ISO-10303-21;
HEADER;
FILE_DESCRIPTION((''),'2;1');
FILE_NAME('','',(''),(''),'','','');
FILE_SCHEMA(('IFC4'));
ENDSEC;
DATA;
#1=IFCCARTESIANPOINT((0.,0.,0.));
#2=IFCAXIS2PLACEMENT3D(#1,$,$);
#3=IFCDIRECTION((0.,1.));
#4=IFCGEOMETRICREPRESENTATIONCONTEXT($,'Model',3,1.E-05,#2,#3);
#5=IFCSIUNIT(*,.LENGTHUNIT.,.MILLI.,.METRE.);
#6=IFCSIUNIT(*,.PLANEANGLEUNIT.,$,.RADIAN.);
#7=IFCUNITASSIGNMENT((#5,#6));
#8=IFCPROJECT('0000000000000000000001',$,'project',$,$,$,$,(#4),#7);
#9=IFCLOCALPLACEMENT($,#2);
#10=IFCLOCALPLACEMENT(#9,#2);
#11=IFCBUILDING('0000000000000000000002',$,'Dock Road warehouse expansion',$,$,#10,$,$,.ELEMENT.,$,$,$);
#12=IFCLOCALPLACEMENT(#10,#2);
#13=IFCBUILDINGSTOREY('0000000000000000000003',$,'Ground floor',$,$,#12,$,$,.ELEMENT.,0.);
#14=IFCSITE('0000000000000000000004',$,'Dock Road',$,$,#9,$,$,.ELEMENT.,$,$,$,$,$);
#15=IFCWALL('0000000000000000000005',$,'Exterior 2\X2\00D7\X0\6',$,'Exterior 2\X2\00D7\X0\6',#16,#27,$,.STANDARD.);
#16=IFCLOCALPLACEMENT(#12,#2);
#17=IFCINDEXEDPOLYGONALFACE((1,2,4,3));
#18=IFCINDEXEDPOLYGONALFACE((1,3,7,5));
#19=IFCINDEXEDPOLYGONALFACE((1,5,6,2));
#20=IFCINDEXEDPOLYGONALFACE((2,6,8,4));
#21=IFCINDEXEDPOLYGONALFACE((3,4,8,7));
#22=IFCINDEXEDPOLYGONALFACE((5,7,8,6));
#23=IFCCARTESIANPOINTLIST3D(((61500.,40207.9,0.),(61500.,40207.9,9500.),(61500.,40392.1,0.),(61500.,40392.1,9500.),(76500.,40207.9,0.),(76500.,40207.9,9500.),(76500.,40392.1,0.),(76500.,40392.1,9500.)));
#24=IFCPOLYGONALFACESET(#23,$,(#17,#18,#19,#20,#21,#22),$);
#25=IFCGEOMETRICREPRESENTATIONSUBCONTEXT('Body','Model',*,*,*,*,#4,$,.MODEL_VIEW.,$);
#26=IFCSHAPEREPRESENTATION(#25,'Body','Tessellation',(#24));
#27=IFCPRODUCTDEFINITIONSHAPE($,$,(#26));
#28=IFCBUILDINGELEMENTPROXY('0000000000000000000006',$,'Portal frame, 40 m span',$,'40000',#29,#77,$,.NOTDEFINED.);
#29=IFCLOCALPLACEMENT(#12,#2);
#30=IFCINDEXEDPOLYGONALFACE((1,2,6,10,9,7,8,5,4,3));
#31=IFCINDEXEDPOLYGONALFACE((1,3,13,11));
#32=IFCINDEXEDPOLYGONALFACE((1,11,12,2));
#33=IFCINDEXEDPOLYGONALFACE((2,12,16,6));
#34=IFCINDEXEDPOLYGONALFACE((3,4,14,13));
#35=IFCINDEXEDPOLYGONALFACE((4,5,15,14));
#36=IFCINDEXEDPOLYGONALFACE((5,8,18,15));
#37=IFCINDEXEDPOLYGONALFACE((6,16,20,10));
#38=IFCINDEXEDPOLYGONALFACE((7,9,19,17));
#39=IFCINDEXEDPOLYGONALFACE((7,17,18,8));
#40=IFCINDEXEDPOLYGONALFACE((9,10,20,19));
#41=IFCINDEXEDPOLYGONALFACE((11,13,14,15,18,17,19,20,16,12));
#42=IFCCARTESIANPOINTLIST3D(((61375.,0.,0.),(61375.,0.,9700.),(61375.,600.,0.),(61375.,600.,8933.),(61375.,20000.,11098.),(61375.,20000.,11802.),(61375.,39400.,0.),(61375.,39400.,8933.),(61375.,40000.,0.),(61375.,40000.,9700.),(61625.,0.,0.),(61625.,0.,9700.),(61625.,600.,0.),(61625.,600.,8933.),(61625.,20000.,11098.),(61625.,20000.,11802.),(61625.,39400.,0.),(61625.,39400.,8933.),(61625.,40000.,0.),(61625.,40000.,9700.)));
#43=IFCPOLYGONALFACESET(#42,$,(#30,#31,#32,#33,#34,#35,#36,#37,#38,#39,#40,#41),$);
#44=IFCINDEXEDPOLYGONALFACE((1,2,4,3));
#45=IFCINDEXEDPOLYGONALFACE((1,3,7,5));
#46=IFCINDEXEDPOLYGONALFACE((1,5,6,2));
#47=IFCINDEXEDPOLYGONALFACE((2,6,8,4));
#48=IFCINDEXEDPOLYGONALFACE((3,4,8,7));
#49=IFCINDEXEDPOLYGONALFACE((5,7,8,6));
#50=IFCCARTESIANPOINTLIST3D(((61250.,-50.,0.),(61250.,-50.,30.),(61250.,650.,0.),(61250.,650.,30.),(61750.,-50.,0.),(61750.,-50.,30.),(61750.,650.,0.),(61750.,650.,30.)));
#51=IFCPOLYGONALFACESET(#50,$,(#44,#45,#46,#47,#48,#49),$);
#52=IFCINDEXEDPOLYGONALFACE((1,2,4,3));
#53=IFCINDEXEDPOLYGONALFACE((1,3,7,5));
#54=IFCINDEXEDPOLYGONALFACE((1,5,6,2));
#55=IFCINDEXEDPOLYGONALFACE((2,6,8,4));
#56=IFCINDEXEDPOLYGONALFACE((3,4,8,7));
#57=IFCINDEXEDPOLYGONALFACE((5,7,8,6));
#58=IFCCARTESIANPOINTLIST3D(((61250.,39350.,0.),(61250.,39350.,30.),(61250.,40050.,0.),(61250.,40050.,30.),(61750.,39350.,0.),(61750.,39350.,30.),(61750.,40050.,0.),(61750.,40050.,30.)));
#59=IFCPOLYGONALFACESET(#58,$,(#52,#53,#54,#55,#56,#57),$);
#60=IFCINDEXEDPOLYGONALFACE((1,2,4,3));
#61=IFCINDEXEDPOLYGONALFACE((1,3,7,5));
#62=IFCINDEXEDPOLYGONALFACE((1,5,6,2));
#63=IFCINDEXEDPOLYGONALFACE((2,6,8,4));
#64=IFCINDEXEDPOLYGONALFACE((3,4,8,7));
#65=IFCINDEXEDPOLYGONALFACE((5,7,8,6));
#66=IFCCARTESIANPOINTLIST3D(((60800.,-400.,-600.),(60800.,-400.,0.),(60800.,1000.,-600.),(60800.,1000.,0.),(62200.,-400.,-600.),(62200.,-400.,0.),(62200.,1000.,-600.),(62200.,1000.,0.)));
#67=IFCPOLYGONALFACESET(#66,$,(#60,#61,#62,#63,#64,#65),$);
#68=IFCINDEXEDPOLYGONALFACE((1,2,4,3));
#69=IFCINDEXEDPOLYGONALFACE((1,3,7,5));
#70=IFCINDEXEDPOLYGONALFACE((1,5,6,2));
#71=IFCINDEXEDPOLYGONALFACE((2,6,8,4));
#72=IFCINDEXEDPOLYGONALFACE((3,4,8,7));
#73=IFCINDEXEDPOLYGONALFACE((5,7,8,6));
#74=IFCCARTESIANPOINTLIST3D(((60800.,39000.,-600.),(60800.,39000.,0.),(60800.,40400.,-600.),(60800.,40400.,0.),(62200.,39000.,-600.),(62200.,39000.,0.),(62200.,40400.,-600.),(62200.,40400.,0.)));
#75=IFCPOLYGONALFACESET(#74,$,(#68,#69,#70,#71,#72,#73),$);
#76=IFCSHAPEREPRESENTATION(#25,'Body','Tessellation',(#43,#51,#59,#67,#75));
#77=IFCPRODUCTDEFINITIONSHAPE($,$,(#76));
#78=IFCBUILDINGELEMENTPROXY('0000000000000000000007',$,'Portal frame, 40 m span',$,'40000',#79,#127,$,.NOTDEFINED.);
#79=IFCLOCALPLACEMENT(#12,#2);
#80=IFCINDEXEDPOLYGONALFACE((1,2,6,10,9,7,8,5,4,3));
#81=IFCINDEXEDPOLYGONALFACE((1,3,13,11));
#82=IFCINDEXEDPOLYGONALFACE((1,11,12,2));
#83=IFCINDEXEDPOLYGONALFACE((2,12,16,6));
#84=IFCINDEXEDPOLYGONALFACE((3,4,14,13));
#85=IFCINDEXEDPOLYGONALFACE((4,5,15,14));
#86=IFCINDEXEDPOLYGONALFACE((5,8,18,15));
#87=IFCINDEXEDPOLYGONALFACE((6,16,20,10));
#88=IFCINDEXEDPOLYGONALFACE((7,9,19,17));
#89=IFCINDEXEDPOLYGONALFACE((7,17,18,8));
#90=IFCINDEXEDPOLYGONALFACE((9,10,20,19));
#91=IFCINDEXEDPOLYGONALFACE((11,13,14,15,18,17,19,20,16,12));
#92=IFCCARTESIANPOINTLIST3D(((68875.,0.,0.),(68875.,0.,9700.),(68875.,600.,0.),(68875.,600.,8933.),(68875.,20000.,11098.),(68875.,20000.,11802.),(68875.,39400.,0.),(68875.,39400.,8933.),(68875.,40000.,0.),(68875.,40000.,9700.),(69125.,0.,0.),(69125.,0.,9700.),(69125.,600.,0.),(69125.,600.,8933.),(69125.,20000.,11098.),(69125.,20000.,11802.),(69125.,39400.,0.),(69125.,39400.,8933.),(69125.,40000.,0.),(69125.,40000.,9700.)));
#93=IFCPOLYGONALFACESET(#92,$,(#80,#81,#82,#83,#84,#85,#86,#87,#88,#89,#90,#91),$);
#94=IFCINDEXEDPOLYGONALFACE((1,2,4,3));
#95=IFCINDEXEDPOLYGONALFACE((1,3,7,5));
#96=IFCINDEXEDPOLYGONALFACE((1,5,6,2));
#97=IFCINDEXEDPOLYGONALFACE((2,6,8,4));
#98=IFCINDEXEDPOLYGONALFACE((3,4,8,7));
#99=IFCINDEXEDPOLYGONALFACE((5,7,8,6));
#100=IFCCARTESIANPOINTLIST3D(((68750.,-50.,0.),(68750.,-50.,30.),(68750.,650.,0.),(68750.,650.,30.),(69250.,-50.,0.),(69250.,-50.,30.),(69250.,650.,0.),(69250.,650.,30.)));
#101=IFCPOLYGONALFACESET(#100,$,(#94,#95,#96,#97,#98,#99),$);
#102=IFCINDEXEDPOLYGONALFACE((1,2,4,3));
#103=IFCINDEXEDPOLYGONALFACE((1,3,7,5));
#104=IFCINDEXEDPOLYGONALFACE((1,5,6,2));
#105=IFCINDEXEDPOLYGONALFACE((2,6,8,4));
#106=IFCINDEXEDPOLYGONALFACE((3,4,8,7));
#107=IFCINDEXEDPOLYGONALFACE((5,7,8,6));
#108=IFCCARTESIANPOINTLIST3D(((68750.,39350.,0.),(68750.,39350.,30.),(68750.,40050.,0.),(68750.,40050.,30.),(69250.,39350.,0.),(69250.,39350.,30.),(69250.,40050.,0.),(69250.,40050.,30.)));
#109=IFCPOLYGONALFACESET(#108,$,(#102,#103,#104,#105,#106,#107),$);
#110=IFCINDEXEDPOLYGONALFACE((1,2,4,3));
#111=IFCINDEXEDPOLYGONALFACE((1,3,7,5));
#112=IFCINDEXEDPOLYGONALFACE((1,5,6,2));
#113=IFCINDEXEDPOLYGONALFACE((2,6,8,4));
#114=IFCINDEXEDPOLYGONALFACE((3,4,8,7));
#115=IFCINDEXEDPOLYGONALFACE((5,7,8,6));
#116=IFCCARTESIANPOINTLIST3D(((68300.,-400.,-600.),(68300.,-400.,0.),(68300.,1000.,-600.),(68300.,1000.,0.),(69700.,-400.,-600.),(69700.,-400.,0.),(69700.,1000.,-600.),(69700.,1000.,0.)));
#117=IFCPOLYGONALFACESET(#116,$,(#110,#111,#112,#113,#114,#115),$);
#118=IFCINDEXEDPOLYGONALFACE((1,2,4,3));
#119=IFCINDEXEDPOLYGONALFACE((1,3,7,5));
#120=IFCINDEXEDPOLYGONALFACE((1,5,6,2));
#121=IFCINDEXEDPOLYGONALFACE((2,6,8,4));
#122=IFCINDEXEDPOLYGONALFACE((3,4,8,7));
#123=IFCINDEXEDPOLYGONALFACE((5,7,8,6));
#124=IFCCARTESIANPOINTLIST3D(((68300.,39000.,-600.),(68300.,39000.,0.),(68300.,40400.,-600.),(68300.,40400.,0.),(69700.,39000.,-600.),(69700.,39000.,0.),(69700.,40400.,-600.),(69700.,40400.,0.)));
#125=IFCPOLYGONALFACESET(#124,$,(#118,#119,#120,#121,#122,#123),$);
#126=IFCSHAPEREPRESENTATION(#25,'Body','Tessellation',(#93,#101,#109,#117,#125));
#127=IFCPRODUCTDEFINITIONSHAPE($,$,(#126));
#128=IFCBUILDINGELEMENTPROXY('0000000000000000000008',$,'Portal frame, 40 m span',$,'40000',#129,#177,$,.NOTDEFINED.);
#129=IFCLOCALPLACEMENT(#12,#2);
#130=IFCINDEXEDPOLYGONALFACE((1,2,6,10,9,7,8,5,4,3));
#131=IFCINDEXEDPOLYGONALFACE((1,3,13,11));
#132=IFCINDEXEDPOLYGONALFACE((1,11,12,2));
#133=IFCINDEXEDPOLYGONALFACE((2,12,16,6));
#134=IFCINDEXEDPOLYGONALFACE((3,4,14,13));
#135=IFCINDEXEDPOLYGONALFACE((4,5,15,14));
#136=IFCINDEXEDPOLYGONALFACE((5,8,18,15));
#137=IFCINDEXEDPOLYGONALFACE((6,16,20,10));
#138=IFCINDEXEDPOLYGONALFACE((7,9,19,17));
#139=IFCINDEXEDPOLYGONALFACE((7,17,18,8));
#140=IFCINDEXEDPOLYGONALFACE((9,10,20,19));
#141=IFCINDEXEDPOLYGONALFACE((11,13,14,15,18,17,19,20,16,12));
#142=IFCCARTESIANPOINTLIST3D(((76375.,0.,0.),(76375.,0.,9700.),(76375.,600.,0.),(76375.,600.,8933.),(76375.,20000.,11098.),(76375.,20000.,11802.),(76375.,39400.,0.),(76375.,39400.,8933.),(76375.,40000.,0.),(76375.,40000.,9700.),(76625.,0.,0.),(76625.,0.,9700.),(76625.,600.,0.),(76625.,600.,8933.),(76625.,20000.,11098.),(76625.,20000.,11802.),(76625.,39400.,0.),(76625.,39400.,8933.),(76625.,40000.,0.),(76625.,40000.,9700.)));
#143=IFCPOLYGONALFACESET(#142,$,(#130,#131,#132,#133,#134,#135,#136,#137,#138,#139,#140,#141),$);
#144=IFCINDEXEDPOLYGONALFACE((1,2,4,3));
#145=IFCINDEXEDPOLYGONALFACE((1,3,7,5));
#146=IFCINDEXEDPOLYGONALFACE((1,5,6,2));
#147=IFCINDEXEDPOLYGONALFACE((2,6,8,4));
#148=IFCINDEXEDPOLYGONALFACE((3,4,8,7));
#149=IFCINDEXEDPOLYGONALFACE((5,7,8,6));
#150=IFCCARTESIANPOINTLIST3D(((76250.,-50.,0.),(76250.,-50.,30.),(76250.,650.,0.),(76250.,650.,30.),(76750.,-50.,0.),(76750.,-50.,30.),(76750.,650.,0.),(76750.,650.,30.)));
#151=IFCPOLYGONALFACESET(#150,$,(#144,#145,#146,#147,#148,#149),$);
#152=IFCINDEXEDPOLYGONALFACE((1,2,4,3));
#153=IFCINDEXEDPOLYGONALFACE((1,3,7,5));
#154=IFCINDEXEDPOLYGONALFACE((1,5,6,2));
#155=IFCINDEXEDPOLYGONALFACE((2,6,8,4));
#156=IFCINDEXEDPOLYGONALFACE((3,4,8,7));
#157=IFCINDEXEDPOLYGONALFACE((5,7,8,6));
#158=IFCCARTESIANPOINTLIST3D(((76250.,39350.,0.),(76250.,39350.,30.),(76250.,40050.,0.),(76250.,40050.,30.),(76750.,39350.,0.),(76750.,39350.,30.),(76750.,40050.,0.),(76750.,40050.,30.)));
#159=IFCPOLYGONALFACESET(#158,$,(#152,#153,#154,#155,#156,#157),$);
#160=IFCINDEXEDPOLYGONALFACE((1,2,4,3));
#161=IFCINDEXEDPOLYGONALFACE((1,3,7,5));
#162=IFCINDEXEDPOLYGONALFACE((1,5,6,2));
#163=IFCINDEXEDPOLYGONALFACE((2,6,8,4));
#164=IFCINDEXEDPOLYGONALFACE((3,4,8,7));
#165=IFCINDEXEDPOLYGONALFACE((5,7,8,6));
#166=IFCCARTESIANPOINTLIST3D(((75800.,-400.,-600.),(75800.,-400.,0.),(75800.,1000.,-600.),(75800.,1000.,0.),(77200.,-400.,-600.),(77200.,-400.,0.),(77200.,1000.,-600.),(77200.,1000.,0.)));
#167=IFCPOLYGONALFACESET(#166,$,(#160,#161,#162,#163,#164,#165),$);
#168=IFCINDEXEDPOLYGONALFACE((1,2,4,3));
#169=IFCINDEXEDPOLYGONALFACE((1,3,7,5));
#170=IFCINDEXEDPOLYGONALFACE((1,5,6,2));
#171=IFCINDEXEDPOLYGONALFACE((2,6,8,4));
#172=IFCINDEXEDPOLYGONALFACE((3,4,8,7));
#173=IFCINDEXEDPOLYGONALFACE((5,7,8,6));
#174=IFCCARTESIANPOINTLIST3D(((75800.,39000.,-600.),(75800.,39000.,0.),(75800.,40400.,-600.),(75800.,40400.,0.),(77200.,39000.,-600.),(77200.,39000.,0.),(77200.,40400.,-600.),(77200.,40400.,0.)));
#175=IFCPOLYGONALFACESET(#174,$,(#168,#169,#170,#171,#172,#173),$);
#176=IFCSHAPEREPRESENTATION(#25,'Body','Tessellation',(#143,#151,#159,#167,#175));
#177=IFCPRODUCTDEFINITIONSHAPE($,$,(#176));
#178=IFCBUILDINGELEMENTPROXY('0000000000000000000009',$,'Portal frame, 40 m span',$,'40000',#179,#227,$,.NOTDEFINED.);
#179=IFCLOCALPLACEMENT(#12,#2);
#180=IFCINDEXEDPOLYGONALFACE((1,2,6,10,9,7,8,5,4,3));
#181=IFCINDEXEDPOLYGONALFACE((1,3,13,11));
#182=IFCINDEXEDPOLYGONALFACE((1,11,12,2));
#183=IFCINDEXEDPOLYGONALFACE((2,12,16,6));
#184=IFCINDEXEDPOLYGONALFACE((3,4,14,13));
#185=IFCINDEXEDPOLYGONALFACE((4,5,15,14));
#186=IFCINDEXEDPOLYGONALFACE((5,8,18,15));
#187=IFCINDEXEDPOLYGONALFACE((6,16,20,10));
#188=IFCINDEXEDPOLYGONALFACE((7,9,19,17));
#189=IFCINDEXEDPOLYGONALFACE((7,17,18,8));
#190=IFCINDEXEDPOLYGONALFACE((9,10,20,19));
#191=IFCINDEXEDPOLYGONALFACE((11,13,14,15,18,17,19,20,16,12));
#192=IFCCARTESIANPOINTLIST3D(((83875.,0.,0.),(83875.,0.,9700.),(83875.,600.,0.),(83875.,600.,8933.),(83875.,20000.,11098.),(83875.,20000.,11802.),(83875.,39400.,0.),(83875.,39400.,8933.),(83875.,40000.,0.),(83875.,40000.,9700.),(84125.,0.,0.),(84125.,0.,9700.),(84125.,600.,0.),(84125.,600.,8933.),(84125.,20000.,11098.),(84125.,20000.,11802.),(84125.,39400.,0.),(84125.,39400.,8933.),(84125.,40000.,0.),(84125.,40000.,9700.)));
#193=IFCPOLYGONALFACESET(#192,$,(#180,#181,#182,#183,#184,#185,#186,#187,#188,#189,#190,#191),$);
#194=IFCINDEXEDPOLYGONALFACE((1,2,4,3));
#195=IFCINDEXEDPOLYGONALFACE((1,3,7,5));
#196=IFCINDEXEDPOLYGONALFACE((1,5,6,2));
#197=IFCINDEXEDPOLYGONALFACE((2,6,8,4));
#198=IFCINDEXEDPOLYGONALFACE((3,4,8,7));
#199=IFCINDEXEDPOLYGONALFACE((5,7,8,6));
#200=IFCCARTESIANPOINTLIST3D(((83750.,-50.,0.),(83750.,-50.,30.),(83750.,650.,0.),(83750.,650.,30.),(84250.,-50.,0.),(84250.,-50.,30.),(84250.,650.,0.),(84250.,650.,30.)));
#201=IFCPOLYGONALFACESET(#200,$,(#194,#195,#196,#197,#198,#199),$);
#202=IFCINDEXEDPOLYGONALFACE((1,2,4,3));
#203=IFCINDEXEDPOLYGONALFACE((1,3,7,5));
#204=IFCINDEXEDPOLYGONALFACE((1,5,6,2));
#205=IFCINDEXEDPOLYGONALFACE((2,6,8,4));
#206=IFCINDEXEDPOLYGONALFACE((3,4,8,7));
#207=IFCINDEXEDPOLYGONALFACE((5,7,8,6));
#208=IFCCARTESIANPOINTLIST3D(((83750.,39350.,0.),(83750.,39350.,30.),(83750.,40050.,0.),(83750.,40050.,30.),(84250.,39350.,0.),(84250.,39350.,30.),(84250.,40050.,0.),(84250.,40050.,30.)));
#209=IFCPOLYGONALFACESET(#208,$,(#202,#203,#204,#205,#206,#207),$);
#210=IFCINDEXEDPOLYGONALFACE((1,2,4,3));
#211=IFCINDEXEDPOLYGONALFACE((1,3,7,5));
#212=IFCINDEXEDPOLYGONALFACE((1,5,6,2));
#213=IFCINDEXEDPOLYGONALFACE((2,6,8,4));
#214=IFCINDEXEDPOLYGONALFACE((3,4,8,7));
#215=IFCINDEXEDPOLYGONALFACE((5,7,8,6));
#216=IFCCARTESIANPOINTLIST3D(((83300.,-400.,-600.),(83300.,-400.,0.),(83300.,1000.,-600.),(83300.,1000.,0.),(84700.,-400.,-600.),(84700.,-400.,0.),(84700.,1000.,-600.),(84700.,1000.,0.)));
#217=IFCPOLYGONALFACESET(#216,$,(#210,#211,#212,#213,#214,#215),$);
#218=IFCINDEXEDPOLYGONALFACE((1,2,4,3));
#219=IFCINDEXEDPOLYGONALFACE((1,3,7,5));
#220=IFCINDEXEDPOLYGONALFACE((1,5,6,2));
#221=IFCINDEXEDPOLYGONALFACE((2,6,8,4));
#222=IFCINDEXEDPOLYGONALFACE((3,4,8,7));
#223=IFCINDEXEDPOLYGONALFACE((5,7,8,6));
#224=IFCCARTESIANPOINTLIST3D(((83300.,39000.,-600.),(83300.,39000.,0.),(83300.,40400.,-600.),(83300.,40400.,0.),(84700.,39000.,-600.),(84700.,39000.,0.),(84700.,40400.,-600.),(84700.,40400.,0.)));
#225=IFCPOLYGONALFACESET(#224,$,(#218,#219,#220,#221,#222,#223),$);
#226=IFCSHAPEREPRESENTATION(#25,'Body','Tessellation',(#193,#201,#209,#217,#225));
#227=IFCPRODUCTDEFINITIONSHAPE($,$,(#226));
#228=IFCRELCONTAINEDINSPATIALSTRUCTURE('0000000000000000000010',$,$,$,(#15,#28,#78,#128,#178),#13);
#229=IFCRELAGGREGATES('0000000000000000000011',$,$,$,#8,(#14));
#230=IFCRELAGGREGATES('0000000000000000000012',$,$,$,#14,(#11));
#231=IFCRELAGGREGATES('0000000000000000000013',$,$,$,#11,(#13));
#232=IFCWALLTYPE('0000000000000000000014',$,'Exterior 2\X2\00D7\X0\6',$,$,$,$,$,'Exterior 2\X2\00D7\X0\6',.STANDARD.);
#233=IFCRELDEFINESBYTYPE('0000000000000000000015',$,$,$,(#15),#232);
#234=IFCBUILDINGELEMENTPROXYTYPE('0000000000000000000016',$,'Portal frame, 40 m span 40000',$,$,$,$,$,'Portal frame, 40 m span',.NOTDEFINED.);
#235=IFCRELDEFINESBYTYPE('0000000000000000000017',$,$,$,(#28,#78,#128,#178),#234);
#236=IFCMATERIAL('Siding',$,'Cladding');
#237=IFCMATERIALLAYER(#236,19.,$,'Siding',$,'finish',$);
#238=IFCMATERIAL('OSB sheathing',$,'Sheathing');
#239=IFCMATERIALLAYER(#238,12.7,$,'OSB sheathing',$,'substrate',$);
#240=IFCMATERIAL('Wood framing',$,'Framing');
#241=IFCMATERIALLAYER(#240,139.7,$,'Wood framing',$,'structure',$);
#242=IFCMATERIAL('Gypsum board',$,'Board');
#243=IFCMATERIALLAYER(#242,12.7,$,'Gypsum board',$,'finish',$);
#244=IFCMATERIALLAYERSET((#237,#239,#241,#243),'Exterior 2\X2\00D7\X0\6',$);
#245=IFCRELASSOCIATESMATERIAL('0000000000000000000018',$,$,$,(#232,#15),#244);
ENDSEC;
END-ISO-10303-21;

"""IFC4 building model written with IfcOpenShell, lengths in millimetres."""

from ifc_helpers import new_model, si_unit, direction, frame, origin, place, context, subcontext, project, spatial, polyline, outline, extrude, source, transform, mapped, material, layer, layer_set, layer_usage, type_object, type_shapes, element, save


model = new_model("IFC4")

# Units and contexts
model_context = context("Model", 3, precision=1e-05, world=origin(), true_north=direction((0.0, 1.0)))
body_context = subcontext(model_context, "Body", "Model", "MODEL_VIEW")
ifc_project = project(units=[si_unit("LENGTHUNIT", "METRE", prefix="MILLI"), si_unit("PLANEANGLEUNIT", "RADIAN")], contexts=[model_context])

# Site, building, storey
site_placement = place(None, origin())
site = spatial("IfcSite", under=ifc_project, at=site_placement, Name="Dock Road", CompositionType="ELEMENT")
building_placement = place(site_placement, origin())
building = spatial("IfcBuilding", under=site, at=building_placement, Name="Dock Road warehouse expansion", CompositionType="ELEMENT")
storey_placement = place(building_placement, origin())
storey = spatial("IfcBuildingStorey", under=building, at=storey_placement, Name="Ground floor", CompositionType="ELEMENT", Elevation=0.0)

# Wall
ifc_material_1 = material(Name="Siding", Category="Cladding")
ifc_layer_1 = layer(ifc_material_1, 19.0, Name="Siding", Category="finish")
ifc_material_2 = material(Name="OSB sheathing", Category="Sheathing")
ifc_layer_2 = layer(ifc_material_2, 12.7, Name="OSB sheathing", Category="substrate")
ifc_material_3 = material(Name="Wood framing", Category="Framing")
ifc_layer_3 = layer(ifc_material_3, 139.7, Name="Wood framing", Category="structure")
ifc_material_4 = material(Name="Gypsum board", Category="Board")
ifc_layer_4 = layer(ifc_material_4, 12.7, Name="Gypsum board", Category="finish")
ifc_layer_set_1 = layer_set([ifc_layer_1, ifc_layer_2, ifc_layer_3, ifc_layer_4], Name="Exterior 2×6")
ifc_layer_usage_1 = layer_usage(ifc_layer_set_1, "AXIS2", "NEGATIVE", 92.1)
wall_type_1 = type_object("IfcWallType", Name="Exterior 2×6", ElementType="Exterior 2×6", PredefinedType="STANDARD", material=ifc_layer_set_1)
wall_1_placement = place(storey_placement, frame((61500.0, 40300.0, 0.0), z_axis=(0.0, 0.0, 1.0), x_axis=(1.0, 0.0, 0.0)))
element("IfcWall", 1, at=wall_1_placement, inside=storey, type_object=wall_type_1, material=ifc_layer_usage_1, Name="Exterior 2×6", ObjectType="Exterior 2×6", PredefinedType="STANDARD", context=body_context, shape_type="SweptSolid", body=[
    extrude(outline(polyline([(0.0, -92.1), (15000.0, -92.1), (15000.0, 92.1), (0.0, 92.1), (0.0, -92.1)])), origin(), (0.0, 0.0, 1.0), 9500.0),
])

# Building element proxies
building_element_proxy_type_1 = type_object("IfcBuildingElementProxyType", Name="Portal frame, 40 m span 40000", ElementType="Portal frame, 40 m span", PredefinedType="NOTDEFINED")
shared_shape_1 = source(origin(), body_context, "Body", "SweptSolid", [
    extrude(outline(polyline([(0.0, 0.0), (0.0, 9700.0), (20000.0, 11802.0), (40000.0, 9700.0), (40000.0, 0.0), (39400.0, 0.0), (39400.0, 8933.0), (20000.0, 11098.0), (600.0, 8933.0), (600.0, 0.0), (0.0, 0.0)])), frame((-125.0, 0.0, 0.0), z_axis=(1.0, 0.0, 0.0), x_axis=(0.0, 1.0, 0.0)), (0.0, 0.0, 1.0), 250.0),
    extrude(outline(polyline([(-250.0, -50.0), (250.0, -50.0), (250.0, 650.0), (-250.0, 650.0), (-250.0, -50.0)])), origin(), (0.0, 0.0, 1.0), 30.0),
    extrude(outline(polyline([(-250.0, 39350.0), (250.0, 39350.0), (250.0, 40050.0), (-250.0, 40050.0), (-250.0, 39350.0)])), origin(), (0.0, 0.0, 1.0), 30.0),
    extrude(outline(polyline([(-700.0, -400.0), (700.0, -400.0), (700.0, 1000.0), (-700.0, 1000.0), (-700.0, -400.0)])), frame((0.0, 0.0, -600.0)), (0.0, 0.0, 1.0), 600.0),
    extrude(outline(polyline([(-700.0, 39000.0), (700.0, 39000.0), (700.0, 40400.0), (-700.0, 40400.0), (-700.0, 39000.0)])), frame((0.0, 0.0, -600.0)), (0.0, 0.0, 1.0), 600.0),
])
type_shapes(building_element_proxy_type_1, [shared_shape_1])
for number, where, z_axis, x_axis, name in (
    (2, (61500.0, 0.0, 0.0), (0.0, 0.0, 1.0), (1.0, 0.0, 0.0), "Portal frame, 40 m span"),
    (3, (69000.0, 0.0, 0.0), (0.0, 0.0, 1.0), (1.0, 0.0, 0.0), "Portal frame, 40 m span"),
    (4, (76500.0, 0.0, 0.0), (0.0, 0.0, 1.0), (1.0, 0.0, 0.0), "Portal frame, 40 m span"),
    (5, (84000.0, 0.0, 0.0), (0.0, 0.0, 1.0), (1.0, 0.0, 0.0), "Portal frame, 40 m span"),
):
    element("IfcBuildingElementProxy", number, at=place(storey_placement, frame(where, z_axis=z_axis, x_axis=x_axis)), inside=storey, type_object=building_element_proxy_type_1, Name=name, ObjectType="40000", PredefinedType="NOTDEFINED", context=body_context, shape_type="MappedRepresentation", body=[
        mapped(shared_shape_1, transform((0.0, 0.0, 0.0))),
    ])

save(model, "model.ifc")
